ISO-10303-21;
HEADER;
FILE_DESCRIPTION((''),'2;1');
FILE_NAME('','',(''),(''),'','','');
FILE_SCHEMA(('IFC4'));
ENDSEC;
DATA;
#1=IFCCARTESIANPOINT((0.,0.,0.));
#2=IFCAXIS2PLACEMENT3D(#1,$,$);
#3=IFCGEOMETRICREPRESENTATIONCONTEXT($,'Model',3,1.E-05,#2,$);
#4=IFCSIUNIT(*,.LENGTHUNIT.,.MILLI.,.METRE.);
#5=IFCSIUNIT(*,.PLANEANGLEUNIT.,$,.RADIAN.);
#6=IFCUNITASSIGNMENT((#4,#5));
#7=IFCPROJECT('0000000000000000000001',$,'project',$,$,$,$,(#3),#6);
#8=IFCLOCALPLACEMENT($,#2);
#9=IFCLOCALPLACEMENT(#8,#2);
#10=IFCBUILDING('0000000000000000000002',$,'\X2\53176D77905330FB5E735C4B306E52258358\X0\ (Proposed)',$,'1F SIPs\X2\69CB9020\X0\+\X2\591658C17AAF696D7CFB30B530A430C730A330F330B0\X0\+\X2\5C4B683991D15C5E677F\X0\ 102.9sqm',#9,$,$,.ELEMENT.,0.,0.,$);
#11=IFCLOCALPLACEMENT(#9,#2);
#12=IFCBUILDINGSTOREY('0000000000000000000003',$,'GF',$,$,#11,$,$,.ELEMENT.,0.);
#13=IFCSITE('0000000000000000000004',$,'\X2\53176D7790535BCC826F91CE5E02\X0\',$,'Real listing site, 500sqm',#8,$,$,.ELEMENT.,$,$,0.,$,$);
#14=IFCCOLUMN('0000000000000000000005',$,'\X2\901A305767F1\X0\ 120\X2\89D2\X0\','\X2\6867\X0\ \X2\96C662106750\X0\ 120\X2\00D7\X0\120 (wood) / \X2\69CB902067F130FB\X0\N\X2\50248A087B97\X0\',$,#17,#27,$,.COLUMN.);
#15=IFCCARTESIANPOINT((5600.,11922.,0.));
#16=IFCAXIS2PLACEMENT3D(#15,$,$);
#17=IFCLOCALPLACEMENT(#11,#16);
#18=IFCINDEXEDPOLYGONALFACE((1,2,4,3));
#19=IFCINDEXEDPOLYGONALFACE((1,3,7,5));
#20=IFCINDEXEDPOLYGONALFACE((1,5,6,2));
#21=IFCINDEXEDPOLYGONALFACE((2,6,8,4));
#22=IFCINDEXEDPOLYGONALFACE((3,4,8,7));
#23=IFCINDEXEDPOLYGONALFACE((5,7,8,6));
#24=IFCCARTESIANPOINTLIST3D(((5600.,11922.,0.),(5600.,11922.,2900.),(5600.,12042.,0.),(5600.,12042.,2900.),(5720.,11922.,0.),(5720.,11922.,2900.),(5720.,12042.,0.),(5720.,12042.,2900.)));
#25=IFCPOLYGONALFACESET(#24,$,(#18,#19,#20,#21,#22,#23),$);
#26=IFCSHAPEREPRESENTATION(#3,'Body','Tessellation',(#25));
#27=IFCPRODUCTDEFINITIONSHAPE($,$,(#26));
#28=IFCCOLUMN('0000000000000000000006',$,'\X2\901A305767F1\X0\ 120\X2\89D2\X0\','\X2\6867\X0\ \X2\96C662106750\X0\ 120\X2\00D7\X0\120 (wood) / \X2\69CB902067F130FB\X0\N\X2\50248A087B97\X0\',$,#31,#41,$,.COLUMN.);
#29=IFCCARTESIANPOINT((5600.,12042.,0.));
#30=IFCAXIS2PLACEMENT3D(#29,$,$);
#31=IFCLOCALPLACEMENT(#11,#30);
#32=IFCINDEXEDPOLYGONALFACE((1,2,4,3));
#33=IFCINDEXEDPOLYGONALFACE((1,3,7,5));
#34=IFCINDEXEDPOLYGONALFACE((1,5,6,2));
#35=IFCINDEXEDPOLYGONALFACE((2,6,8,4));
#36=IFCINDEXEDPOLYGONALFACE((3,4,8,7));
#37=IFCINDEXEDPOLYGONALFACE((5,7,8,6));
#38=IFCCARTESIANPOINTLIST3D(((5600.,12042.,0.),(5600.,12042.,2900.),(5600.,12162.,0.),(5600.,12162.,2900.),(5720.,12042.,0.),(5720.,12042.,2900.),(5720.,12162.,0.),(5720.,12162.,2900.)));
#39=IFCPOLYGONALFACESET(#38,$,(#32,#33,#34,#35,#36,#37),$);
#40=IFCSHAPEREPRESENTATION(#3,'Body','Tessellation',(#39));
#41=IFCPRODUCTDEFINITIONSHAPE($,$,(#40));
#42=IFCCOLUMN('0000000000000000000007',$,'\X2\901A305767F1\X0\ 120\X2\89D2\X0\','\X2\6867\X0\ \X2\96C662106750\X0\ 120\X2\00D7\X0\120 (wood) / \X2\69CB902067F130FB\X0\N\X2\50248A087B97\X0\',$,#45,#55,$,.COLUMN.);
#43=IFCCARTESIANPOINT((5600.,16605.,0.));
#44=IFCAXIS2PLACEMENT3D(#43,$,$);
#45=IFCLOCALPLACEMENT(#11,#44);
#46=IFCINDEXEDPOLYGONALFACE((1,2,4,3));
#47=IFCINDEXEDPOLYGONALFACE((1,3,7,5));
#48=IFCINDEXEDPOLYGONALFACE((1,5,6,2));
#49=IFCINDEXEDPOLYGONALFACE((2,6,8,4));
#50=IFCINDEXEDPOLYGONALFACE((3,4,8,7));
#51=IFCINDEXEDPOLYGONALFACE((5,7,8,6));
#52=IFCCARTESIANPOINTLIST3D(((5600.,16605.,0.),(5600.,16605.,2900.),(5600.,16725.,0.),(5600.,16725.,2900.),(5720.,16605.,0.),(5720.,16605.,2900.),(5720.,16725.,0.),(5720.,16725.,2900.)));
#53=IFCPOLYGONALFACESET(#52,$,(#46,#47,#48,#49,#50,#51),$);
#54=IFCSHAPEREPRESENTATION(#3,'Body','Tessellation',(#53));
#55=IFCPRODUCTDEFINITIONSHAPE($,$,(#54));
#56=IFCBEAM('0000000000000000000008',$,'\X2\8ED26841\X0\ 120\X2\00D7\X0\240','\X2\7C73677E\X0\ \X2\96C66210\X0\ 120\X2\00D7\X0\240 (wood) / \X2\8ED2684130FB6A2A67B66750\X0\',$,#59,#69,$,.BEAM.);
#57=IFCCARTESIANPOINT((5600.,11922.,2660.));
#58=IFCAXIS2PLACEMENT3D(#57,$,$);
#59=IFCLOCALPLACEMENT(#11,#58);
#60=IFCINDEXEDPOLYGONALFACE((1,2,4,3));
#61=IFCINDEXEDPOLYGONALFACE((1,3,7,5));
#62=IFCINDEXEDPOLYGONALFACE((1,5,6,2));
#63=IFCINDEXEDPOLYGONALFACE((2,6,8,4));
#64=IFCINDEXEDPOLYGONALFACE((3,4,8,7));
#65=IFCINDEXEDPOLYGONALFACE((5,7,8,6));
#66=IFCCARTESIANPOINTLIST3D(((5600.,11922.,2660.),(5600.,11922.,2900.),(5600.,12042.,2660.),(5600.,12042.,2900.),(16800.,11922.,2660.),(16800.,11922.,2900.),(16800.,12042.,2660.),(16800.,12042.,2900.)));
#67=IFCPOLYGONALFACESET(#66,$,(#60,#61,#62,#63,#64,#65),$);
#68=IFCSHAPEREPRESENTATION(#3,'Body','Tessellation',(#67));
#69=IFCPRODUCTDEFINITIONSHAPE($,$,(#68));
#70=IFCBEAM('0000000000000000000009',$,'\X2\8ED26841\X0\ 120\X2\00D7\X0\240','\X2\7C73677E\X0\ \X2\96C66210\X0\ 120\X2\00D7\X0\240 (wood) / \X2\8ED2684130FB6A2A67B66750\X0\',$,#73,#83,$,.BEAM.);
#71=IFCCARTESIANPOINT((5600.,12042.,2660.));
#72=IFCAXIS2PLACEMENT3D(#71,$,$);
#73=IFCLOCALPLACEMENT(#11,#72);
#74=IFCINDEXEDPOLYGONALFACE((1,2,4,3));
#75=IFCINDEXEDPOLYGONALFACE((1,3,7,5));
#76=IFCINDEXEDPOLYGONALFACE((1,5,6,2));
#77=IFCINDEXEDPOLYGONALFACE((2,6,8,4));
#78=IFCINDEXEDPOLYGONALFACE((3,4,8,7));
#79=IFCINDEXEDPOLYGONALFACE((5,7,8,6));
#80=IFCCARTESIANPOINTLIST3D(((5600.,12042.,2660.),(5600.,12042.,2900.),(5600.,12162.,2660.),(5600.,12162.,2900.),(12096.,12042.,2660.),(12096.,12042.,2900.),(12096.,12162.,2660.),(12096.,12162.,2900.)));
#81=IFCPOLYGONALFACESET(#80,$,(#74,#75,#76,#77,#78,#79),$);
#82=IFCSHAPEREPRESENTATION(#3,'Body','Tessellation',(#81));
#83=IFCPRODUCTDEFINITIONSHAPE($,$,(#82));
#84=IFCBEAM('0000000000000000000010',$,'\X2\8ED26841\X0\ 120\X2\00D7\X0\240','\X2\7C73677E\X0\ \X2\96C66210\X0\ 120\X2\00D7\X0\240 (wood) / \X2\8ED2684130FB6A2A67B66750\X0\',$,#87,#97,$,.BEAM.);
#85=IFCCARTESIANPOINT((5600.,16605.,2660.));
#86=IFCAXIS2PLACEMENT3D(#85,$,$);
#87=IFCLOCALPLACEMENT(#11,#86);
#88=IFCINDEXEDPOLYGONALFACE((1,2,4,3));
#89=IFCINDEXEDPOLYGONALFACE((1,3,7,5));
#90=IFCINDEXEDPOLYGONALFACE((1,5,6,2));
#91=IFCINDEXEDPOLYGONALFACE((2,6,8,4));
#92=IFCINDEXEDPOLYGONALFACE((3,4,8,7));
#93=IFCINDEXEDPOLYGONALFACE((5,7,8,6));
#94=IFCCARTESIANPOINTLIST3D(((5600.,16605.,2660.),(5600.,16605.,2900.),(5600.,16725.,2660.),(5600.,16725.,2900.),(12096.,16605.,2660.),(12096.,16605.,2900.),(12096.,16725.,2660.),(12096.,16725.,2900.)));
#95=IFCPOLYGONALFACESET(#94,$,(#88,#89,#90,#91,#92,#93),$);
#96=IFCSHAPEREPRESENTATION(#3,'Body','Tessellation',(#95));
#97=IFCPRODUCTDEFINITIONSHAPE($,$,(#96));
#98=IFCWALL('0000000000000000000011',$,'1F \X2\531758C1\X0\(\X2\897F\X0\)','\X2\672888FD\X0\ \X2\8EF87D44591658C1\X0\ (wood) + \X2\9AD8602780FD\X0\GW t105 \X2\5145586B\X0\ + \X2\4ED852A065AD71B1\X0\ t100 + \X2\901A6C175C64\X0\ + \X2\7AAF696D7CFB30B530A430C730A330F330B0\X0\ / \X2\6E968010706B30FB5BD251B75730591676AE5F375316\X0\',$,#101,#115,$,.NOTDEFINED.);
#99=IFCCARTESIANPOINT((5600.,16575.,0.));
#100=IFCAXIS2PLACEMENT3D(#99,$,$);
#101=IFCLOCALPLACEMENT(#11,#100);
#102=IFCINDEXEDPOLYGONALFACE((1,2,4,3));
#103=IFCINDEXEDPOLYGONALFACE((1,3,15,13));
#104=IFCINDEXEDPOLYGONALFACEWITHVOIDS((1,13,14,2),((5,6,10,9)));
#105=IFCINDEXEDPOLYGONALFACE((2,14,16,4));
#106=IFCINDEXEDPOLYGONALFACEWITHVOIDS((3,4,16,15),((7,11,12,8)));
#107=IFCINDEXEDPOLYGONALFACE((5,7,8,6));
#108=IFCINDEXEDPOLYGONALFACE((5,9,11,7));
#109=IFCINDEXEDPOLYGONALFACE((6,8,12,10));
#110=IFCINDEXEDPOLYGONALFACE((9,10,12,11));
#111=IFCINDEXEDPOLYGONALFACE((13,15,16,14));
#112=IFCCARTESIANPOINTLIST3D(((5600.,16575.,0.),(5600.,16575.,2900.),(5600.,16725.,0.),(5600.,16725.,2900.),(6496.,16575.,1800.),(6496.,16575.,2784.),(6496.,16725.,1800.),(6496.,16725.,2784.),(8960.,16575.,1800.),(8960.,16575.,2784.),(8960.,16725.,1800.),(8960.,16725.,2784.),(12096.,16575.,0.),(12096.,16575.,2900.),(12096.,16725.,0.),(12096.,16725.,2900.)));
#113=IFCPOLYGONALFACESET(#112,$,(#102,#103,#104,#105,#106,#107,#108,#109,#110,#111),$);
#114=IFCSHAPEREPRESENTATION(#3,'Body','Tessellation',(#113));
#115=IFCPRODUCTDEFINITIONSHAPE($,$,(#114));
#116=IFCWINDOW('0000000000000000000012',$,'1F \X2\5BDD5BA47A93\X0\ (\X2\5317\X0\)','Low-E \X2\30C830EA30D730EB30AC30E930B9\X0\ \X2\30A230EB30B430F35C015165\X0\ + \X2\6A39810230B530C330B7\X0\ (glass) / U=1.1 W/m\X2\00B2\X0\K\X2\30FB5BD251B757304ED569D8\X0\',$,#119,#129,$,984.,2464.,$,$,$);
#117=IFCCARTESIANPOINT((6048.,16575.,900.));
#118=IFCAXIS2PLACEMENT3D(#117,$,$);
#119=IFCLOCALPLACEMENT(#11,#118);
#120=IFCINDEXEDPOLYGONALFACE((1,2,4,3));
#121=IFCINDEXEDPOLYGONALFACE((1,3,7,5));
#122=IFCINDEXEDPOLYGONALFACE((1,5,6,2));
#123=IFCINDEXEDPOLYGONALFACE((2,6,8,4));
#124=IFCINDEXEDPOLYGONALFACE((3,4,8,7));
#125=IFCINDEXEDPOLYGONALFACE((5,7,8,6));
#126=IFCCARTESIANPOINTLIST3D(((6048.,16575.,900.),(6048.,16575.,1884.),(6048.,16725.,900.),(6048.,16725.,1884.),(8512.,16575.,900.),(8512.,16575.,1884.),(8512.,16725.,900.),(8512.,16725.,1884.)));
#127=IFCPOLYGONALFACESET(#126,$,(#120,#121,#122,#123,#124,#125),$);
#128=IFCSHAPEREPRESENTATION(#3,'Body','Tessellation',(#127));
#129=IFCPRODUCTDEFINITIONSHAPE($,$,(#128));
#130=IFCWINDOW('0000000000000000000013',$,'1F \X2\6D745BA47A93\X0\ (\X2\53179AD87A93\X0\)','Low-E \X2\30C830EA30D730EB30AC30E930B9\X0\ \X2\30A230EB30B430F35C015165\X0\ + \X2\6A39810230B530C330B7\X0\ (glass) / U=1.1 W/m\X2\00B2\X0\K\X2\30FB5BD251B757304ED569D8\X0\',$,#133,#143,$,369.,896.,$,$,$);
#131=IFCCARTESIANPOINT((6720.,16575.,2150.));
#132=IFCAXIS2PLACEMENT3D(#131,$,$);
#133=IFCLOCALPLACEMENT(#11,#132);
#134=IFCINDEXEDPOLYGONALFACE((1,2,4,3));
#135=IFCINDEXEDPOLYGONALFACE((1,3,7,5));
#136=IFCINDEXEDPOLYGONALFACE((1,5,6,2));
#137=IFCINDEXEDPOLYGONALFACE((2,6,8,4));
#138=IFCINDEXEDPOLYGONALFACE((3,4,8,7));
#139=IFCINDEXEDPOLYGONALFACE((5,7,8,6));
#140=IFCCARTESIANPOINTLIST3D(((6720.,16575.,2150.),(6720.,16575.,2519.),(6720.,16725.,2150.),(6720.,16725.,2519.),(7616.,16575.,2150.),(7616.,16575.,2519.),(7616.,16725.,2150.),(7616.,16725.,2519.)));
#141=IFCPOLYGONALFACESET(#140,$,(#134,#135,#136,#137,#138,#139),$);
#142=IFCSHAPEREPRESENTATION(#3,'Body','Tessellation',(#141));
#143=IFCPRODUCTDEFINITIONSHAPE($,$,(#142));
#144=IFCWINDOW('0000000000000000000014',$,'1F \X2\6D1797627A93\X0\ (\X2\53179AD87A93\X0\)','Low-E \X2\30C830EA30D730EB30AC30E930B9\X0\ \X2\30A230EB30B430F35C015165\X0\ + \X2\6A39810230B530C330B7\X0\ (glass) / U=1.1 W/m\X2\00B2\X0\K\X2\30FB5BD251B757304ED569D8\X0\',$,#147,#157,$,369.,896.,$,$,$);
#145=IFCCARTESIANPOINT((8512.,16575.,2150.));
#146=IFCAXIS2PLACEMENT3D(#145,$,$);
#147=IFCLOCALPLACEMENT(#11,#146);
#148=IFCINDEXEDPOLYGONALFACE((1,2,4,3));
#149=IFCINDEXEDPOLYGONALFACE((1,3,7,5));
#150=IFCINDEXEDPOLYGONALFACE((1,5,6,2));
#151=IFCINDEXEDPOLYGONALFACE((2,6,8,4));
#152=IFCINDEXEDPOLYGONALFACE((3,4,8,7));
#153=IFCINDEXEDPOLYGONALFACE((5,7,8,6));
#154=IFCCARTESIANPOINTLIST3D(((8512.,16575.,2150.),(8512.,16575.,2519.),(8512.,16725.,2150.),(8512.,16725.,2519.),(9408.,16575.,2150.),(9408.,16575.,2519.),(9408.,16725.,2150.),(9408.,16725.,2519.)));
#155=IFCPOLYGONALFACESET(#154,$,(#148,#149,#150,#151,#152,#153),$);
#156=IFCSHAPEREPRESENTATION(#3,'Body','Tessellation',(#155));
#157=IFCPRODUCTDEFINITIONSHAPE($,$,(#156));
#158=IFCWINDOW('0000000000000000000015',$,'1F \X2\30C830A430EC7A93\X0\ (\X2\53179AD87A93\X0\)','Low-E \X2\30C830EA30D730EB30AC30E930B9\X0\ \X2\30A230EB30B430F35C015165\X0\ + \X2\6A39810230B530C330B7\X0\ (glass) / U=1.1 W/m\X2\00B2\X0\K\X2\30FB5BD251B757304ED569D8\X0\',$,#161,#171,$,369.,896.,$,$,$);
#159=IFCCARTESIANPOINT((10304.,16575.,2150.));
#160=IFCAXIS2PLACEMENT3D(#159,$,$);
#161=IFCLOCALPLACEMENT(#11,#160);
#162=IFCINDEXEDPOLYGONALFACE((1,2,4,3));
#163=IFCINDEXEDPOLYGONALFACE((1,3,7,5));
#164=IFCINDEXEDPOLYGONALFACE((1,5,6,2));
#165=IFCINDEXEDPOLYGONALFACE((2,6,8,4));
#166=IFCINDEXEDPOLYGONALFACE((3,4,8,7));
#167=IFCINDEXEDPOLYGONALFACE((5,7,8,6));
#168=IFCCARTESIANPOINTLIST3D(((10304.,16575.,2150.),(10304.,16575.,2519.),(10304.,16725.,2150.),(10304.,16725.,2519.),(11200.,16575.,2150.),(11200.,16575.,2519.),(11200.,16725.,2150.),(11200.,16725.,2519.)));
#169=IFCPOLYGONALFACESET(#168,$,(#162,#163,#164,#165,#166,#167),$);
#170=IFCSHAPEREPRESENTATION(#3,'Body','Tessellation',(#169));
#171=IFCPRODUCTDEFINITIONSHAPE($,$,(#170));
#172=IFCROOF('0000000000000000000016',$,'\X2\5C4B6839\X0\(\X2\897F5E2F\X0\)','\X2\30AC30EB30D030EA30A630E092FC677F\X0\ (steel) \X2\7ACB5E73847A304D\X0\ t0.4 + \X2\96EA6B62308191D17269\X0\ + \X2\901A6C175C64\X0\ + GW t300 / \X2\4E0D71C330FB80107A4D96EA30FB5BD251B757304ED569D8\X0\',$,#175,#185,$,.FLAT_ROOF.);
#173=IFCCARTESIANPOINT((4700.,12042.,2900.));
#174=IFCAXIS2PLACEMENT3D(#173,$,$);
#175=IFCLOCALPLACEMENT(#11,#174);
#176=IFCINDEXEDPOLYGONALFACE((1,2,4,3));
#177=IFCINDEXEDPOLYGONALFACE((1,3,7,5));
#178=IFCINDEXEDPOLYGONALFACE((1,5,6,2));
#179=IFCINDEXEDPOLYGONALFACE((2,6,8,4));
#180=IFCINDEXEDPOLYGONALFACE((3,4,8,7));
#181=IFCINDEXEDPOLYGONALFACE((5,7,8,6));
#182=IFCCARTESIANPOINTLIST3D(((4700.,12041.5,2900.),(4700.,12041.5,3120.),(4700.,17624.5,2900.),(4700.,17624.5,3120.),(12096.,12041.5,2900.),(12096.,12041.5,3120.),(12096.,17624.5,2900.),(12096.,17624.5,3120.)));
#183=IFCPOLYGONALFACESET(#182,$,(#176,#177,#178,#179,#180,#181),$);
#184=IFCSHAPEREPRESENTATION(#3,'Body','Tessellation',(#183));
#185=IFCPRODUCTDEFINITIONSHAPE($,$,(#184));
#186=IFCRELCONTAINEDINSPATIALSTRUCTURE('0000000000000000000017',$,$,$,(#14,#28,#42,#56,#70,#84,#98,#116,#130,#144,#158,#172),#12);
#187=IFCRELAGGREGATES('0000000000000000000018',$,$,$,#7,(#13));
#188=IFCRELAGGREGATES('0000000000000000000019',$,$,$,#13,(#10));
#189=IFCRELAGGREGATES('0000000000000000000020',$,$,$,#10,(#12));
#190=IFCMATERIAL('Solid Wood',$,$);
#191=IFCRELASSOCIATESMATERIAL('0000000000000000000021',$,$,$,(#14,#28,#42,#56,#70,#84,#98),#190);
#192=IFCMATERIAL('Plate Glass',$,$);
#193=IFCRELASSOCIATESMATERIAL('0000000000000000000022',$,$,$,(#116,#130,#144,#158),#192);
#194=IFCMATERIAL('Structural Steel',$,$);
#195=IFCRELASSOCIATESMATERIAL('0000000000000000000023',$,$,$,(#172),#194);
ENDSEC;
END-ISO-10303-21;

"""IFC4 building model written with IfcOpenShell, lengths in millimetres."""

from ifc_helpers import new_model, si_unit, frame, frame_2d, origin, place, context, project, spatial, rectangle, extrude, material, element, fill, save


model = new_model("IFC4")

# Units and contexts
model_context = context("Model", 3, precision=1e-05, world=origin())
ifc_project = project(units=[si_unit("LENGTHUNIT", "METRE", prefix="MILLI"), si_unit("PLANEANGLEUNIT", "RADIAN")], contexts=[model_context])

# Site, building, storey
site_placement = place(None, origin())
site = spatial("IfcSite", under=ifc_project, at=site_placement, Name="北海道富良野市", ObjectType="Real listing site, 500sqm", CompositionType="ELEMENT", RefElevation=0.0)
building_placement = place(site_placement, origin())
building = spatial("IfcBuilding", under=site, at=building_placement, Name="北海道・平屋の別荘 (Proposed)", ObjectType="1F SIPs構造+外壁窯業系サイディング+屋根金属板 102.9sqm", CompositionType="ELEMENT", ElevationOfRefHeight=0.0, ElevationOfTerrain=0.0)
storey_placement = place(building_placement, origin())
storey = spatial("IfcBuildingStorey", under=building, at=storey_placement, Name="GF", CompositionType="ELEMENT", Elevation=0.0)

# Columns
ifc_material_1 = material(Name="Solid Wood")
column_1_placement = place(storey_placement, frame((5600.0, 11922.0, 0.0)))
element("IfcColumn", 1, at=column_1_placement, inside=storey, material=ifc_material_1, Name="通し柱 120角", Description="桧 集成材 120×120 (wood) / 構造柱・N値計算", PredefinedType="COLUMN", context=model_context, shape_type="SweptSolid", body=[
    extrude(rectangle(XDim=120.0, YDim=120.0, at=frame_2d((60.0, 60.0))), frame((5600.0, 11922.0, 0.0)), (0.0, 0.0, 1.0), 2900.0),
])
column_2_placement = place(storey_placement, frame((5600.0, 12042.0, 0.0)))
element("IfcColumn", 2, at=column_2_placement, inside=storey, material=ifc_material_1, Name="通し柱 120角", Description="桧 集成材 120×120 (wood) / 構造柱・N値計算", PredefinedType="COLUMN", context=model_context, shape_type="SweptSolid", body=[
    extrude(rectangle(XDim=120.0, YDim=120.0, at=frame_2d((60.0, 60.0))), frame((5600.0, 12042.0, 0.0)), (0.0, 0.0, 1.0), 2900.0),
])
column_3_placement = place(storey_placement, frame((5600.0, 16605.0, 0.0)))
element("IfcColumn", 3, at=column_3_placement, inside=storey, material=ifc_material_1, Name="通し柱 120角", Description="桧 集成材 120×120 (wood) / 構造柱・N値計算", PredefinedType="COLUMN", context=model_context, shape_type="SweptSolid", body=[
    extrude(rectangle(XDim=120.0, YDim=120.0, at=frame_2d((60.0, 60.0))), frame((5600.0, 16605.0, 0.0)), (0.0, 0.0, 1.0), 2900.0),
])

# Beams
beam_1_placement = place(storey_placement, frame((5600.0, 11922.0, 2660.0)))
element("IfcBeam", 4, at=beam_1_placement, inside=storey, material=ifc_material_1, Name="軒桁 120×240", Description="米松 集成 120×240 (wood) / 軒桁・横架材", PredefinedType="BEAM", context=model_context, shape_type="SweptSolid", body=[
    extrude(rectangle(XDim=11200.0, YDim=120.0, at=frame_2d((5600.0, 60.0))), frame((5600.0, 11922.0, 2660.0)), (0.0, 0.0, 1.0), 240.0),
])
beam_2_placement = place(storey_placement, frame((5600.0, 12042.0, 2660.0)))
element("IfcBeam", 5, at=beam_2_placement, inside=storey, material=ifc_material_1, Name="軒桁 120×240", Description="米松 集成 120×240 (wood) / 軒桁・横架材", PredefinedType="BEAM", context=model_context, shape_type="SweptSolid", body=[
    extrude(rectangle(XDim=6496.0, YDim=120.0, at=frame_2d((3248.0, 60.0))), frame((5600.0, 12042.0, 2660.0)), (0.0, 0.0, 1.0), 240.0),
])
beam_3_placement = place(storey_placement, frame((5600.0, 16605.0, 2660.0)))
element("IfcBeam", 6, at=beam_3_placement, inside=storey, material=ifc_material_1, Name="軒桁 120×240", Description="米松 集成 120×240 (wood) / 軒桁・横架材", PredefinedType="BEAM", context=model_context, shape_type="SweptSolid", body=[
    extrude(rectangle(XDim=6496.0, YDim=120.0, at=frame_2d((3248.0, 60.0))), frame((5600.0, 16605.0, 2660.0)), (0.0, 0.0, 1.0), 240.0),
])

# Wall, openings, windows
wall_1_placement = place(storey_placement, frame((5600.0, 16575.0, 0.0)))
wall_1 = element("IfcWall", 7, at=wall_1_placement, inside=storey, material=ifc_material_1, Name="1F 北壁(西)", Description="木製 軸組外壁 (wood) + 高性能GW t105 充填 + 付加断熱 t100 + 通気層 + 窯業系サイディング / 準耐火・寒冷地外皮強化", PredefinedType="NOTDEFINED", context=model_context, shape_type="SweptSolid", body=[
    extrude(rectangle(XDim=6496.0, YDim=150.0, at=frame_2d((3248.0, 75.0))), frame((5600.0, 16575.0, 0.0)), (0.0, 0.0, 1.0), 2900.0),
])
opening_1_placement = place(storey_placement, frame((6048.0, 16575.0, 900.0)))
opening_1 = element("IfcOpeningElement", 8, at=opening_1_placement, cuts=wall_1, PredefinedType="NOTDEFINED", context=model_context, shape_type="SweptSolid", body=[
    extrude(rectangle(XDim=2464.0, YDim=150.0, at=frame_2d((1232.0, 75.0))), frame((6048.0, 16575.0, 900.0)), (0.0, 0.0, 1.0), 984.0),
])
opening_2_placement = place(storey_placement, frame((6720.0, 16575.0, 2150.0)))
opening_2 = element("IfcOpeningElement", 9, at=opening_2_placement, cuts=wall_1, PredefinedType="NOTDEFINED", context=model_context, shape_type="SweptSolid", body=[
    extrude(rectangle(XDim=896.0, YDim=150.0, at=frame_2d((448.0, 75.0))), frame((6720.0, 16575.0, 2150.0)), (0.0, 0.0, 1.0), 369.0),
])
opening_3_placement = place(storey_placement, frame((8512.0, 16575.0, 2150.0)))
opening_3 = element("IfcOpeningElement", 10, at=opening_3_placement, cuts=wall_1, PredefinedType="NOTDEFINED", context=model_context, shape_type="SweptSolid", body=[
    extrude(rectangle(XDim=896.0, YDim=150.0, at=frame_2d((448.0, 75.0))), frame((8512.0, 16575.0, 2150.0)), (0.0, 0.0, 1.0), 369.0),
])
opening_4_placement = place(storey_placement, frame((10304.0, 16575.0, 2150.0)))
opening_4 = element("IfcOpeningElement", 11, at=opening_4_placement, cuts=wall_1, PredefinedType="NOTDEFINED", context=model_context, shape_type="SweptSolid", body=[
    extrude(rectangle(XDim=896.0, YDim=150.0, at=frame_2d((448.0, 75.0))), frame((10304.0, 16575.0, 2150.0)), (0.0, 0.0, 1.0), 369.0),
])
ifc_material_2 = material(Name="Plate Glass")
window_1_placement = place(storey_placement, frame((6048.0, 16575.0, 900.0)))
window_1 = element("IfcWindow", 12, at=window_1_placement, inside=storey, material=ifc_material_2, Name="1F 寝室窓 (北)", Description="Low-E トリプルガラス アルゴン封入 + 樹脂サッシ (glass) / U=1.1 W/m²K・寒冷地仕様", OverallHeight=984.0, OverallWidth=2464.0, context=model_context, shape_type="SweptSolid", body=[
    extrude(rectangle(XDim=2464.0, YDim=150.0, at=frame_2d((1232.0, 75.0))), frame((6048.0, 16575.0, 900.0)), (0.0, 0.0, 1.0), 984.0),
])
fill(opening_1, window_1)
window_2_placement = place(storey_placement, frame((6720.0, 16575.0, 2150.0)))
window_2 = element("IfcWindow", 13, at=window_2_placement, inside=storey, material=ifc_material_2, Name="1F 浴室窓 (北高窓)", Description="Low-E トリプルガラス アルゴン封入 + 樹脂サッシ (glass) / U=1.1 W/m²K・寒冷地仕様", OverallHeight=369.0, OverallWidth=896.0, context=model_context, shape_type="SweptSolid", body=[
    extrude(rectangle(XDim=896.0, YDim=150.0, at=frame_2d((448.0, 75.0))), frame((6720.0, 16575.0, 2150.0)), (0.0, 0.0, 1.0), 369.0),
])
fill(opening_2, window_2)
window_3_placement = place(storey_placement, frame((8512.0, 16575.0, 2150.0)))
window_3 = element("IfcWindow", 14, at=window_3_placement, inside=storey, material=ifc_material_2, Name="1F 洗面窓 (北高窓)", Description="Low-E トリプルガラス アルゴン封入 + 樹脂サッシ (glass) / U=1.1 W/m²K・寒冷地仕様", OverallHeight=369.0, OverallWidth=896.0, context=model_context, shape_type="SweptSolid", body=[
    extrude(rectangle(XDim=896.0, YDim=150.0, at=frame_2d((448.0, 75.0))), frame((8512.0, 16575.0, 2150.0)), (0.0, 0.0, 1.0), 369.0),
])
fill(opening_3, window_3)
window_4_placement = place(storey_placement, frame((10304.0, 16575.0, 2150.0)))
window_4 = element("IfcWindow", 15, at=window_4_placement, inside=storey, material=ifc_material_2, Name="1F トイレ窓 (北高窓)", Description="Low-E トリプルガラス アルゴン封入 + 樹脂サッシ (glass) / U=1.1 W/m²K・寒冷地仕様", OverallHeight=369.0, OverallWidth=896.0, context=model_context, shape_type="SweptSolid", body=[
    extrude(rectangle(XDim=896.0, YDim=150.0, at=frame_2d((448.0, 75.0))), frame((10304.0, 16575.0, 2150.0)), (0.0, 0.0, 1.0), 369.0),
])
fill(opening_4, window_4)

# Roof
ifc_material_3 = material(Name="Structural Steel")
roof_placement = place(storey_placement, frame((4700.0, 12042.0, 2900.0)))
element("IfcRoof", 16, at=roof_placement, inside=storey, material=ifc_material_3, Name="屋根(西帯)", Description="ガルバリウム鋼板 (steel) 立平葺き t0.4 + 雪止め金物 + 通気層 + GW t300 / 不燃・耐積雪・寒冷地仕様", PredefinedType="FLAT_ROOF", context=model_context, shape_type="SweptSolid", body=[
    extrude(rectangle(XDim=7396.0, YDim=5583.0, at=frame_2d((3698.0, 2791.0))), frame((4700.0, 12042.0, 2900.0)), (0.0, 0.0, 1.0), 220.0),
])

save(model, "model.ifc")
